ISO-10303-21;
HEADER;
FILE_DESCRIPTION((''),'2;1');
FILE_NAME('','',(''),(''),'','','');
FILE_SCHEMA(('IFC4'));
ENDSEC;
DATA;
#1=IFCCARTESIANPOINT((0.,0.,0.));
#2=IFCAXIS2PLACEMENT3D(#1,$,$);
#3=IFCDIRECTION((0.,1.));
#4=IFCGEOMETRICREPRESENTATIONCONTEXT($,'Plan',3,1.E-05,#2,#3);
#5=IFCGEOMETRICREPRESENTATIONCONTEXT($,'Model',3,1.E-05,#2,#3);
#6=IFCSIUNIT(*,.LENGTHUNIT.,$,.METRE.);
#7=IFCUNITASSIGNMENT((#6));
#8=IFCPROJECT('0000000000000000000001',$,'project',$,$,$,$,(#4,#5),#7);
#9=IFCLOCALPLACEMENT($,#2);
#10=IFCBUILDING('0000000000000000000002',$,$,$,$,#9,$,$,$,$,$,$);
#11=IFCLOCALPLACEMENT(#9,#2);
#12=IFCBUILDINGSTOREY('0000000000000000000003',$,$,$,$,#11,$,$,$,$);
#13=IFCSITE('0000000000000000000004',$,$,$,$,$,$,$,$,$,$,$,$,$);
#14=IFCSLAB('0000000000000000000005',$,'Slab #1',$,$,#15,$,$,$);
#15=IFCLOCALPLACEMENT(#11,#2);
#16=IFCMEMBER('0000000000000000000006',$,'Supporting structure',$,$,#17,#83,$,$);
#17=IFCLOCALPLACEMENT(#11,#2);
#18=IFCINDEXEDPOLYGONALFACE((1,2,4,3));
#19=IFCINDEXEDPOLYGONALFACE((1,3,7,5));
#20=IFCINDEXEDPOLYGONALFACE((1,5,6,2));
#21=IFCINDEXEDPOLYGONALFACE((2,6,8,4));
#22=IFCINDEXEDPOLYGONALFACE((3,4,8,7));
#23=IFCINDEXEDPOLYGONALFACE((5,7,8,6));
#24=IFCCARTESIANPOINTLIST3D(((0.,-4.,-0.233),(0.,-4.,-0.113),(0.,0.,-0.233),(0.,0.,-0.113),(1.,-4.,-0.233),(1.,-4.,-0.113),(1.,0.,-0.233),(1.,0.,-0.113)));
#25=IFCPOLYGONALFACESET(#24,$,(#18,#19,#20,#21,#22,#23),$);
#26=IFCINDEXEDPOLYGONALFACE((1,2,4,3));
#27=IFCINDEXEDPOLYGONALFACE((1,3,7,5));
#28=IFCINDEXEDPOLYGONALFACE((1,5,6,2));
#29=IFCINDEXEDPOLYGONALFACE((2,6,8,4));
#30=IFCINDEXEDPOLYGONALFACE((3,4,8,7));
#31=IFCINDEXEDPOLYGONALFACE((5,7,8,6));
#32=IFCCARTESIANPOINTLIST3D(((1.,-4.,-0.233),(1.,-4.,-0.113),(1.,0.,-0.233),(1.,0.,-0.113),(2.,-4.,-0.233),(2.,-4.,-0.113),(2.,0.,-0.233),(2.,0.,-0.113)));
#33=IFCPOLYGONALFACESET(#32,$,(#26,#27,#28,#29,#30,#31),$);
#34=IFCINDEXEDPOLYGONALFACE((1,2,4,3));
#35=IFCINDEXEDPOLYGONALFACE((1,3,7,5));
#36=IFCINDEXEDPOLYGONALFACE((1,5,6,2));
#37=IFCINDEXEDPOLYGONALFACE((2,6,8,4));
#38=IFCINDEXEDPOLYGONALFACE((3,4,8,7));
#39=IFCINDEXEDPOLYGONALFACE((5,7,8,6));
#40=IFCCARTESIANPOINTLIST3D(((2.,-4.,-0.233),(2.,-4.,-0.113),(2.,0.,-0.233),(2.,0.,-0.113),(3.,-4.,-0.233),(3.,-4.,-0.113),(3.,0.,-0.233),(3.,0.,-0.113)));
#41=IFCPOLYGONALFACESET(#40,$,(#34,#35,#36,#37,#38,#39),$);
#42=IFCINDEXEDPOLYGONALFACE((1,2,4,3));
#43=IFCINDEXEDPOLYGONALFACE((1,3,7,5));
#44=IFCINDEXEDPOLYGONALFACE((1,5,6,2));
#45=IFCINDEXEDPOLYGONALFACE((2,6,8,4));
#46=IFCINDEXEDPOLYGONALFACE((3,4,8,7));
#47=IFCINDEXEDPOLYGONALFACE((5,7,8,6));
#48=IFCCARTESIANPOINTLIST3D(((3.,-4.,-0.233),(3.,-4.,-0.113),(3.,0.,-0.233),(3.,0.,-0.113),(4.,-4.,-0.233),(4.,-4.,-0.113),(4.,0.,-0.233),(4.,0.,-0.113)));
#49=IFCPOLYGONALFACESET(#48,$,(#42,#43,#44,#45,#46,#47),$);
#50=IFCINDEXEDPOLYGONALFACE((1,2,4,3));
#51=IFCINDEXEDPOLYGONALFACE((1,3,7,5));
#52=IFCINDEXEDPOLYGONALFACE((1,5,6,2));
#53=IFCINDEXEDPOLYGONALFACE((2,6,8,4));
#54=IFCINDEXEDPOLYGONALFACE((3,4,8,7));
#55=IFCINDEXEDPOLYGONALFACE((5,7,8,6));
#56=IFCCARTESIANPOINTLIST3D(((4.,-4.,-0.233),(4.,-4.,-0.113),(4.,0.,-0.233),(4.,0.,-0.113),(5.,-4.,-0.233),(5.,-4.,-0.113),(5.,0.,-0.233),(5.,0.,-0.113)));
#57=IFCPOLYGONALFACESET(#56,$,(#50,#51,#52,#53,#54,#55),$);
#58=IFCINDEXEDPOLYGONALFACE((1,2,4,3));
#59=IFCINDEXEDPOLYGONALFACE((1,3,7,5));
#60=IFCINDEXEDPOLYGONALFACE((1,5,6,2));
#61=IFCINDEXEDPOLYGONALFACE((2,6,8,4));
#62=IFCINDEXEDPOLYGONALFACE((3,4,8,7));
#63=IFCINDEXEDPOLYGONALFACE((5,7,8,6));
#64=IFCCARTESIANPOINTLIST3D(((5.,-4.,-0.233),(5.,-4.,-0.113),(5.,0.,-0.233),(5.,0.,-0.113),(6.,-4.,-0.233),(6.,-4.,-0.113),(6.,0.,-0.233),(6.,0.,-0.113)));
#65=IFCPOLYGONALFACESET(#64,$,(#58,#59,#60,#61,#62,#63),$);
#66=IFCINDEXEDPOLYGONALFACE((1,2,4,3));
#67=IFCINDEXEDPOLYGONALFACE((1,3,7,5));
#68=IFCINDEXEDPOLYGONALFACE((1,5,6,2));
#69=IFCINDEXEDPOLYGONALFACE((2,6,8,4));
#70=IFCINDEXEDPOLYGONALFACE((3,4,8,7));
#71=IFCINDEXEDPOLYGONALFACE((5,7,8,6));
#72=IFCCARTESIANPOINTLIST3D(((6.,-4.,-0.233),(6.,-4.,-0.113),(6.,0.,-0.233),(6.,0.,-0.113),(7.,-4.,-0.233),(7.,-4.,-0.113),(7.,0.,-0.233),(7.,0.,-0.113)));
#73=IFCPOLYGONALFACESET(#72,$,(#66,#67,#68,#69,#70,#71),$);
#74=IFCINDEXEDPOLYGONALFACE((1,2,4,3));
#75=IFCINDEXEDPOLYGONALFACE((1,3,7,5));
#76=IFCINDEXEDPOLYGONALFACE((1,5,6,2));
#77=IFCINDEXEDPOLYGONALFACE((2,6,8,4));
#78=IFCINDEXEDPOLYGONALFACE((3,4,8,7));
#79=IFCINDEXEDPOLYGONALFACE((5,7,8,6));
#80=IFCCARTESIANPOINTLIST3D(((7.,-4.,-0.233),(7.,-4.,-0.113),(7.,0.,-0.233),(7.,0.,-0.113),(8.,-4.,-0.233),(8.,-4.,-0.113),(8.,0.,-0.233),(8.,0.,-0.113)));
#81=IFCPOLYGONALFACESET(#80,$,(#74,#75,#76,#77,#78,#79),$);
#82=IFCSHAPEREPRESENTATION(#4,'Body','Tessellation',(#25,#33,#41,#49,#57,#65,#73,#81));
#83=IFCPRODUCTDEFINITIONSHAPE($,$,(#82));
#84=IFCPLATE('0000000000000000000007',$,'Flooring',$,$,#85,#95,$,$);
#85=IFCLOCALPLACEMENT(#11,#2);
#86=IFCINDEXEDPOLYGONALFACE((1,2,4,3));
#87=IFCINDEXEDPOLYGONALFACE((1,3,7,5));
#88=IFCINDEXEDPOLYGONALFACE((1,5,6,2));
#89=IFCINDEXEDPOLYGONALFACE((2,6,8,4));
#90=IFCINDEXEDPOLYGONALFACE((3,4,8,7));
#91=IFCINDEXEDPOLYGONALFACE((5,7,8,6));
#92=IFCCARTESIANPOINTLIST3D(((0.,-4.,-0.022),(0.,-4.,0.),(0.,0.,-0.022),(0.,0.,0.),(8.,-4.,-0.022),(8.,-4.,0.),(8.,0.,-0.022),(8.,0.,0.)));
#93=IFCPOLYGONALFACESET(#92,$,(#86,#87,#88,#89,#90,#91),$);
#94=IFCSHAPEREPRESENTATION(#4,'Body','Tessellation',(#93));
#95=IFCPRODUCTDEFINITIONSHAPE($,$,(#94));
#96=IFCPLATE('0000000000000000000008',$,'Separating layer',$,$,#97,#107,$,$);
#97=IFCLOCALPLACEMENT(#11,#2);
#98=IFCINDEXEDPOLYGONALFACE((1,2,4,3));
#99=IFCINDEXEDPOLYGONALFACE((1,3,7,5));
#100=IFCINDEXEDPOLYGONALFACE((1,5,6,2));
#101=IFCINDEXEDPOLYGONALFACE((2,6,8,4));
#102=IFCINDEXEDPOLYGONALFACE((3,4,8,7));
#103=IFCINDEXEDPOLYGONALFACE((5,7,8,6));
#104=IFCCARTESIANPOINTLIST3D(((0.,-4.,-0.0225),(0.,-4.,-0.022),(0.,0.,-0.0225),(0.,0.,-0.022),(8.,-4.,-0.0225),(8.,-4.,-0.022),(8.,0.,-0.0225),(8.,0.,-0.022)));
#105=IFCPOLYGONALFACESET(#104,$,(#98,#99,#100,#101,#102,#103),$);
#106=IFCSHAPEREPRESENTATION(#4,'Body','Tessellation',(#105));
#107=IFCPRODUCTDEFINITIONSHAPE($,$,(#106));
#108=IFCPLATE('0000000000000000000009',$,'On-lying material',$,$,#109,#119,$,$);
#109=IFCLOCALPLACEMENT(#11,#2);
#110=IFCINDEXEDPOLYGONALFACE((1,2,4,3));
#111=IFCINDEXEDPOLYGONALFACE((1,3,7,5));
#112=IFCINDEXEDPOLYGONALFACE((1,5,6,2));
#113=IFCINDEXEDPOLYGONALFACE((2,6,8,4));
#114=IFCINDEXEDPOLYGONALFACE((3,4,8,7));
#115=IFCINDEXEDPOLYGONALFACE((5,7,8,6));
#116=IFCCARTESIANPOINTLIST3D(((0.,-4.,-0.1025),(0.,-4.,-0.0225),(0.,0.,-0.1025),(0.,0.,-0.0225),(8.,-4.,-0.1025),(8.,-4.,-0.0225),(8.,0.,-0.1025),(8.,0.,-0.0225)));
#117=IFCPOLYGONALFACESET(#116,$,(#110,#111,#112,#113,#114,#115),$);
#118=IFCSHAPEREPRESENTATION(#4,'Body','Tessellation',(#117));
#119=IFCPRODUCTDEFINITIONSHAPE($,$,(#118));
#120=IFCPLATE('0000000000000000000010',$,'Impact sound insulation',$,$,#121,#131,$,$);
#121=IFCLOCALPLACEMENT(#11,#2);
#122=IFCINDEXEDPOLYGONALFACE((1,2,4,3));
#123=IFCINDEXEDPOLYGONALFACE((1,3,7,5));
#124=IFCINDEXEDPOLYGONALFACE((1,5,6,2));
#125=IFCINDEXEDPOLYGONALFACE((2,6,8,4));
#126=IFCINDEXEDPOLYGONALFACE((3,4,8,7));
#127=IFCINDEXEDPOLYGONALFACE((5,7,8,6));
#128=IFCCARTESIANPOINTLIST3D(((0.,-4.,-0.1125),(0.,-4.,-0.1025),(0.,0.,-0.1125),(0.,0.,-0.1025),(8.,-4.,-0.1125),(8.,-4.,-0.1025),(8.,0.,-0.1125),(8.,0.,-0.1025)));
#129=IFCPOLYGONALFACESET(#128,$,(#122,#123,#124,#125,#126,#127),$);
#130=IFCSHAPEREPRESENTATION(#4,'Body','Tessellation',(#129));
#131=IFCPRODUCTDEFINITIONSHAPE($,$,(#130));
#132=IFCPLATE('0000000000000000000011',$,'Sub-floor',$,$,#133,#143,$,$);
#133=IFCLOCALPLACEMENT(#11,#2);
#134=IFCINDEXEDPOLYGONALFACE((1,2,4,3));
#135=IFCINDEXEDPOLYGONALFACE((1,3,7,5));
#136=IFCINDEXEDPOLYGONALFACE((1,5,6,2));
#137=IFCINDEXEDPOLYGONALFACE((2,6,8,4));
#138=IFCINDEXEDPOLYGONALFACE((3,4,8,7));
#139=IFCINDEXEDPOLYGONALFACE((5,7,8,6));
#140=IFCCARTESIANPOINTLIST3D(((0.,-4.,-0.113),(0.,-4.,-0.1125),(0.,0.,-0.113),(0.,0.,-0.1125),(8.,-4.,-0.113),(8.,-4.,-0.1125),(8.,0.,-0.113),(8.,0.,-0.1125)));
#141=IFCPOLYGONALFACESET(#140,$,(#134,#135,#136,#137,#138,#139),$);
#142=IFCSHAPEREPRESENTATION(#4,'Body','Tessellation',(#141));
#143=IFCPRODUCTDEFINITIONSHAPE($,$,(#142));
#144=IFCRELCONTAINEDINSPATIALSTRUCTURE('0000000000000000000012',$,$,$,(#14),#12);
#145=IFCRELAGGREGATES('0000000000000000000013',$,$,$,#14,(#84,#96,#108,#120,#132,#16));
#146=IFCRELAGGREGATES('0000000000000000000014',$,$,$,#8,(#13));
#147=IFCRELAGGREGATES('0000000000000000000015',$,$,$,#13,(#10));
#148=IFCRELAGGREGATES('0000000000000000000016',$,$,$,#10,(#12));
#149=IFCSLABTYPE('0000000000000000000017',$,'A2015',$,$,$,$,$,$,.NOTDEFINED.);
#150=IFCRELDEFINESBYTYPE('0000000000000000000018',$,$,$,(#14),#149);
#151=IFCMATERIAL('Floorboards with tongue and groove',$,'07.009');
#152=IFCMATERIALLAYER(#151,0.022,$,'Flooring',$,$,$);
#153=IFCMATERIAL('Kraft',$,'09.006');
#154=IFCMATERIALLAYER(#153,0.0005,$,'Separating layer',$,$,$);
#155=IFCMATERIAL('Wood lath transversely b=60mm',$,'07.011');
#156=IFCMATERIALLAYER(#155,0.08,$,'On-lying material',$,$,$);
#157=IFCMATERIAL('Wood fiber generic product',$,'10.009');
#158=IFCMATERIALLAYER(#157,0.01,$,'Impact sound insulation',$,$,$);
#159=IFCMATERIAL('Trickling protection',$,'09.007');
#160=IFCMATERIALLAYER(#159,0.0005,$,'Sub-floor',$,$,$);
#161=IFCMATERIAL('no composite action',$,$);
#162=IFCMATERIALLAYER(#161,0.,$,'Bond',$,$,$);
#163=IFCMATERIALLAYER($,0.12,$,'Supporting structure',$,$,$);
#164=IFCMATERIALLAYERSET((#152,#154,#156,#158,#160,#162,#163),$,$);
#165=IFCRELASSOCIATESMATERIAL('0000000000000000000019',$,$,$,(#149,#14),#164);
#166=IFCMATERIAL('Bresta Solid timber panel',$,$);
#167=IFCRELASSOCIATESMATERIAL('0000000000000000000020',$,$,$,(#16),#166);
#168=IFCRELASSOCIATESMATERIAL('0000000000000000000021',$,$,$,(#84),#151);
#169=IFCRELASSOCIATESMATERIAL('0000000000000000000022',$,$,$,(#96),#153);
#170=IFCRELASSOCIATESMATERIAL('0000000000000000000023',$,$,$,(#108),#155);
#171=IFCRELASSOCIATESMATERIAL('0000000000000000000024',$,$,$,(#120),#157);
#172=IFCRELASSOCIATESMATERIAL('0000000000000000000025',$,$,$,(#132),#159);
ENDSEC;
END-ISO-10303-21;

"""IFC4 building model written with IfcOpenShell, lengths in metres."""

from ifc_helpers import new_model, si_unit, direction, frame, frame_2d, origin, origin_with_axes, place, context, project, spatial, rectangle, extrude, material, layer, layer_set, type_object, element, aggregate, save


model = new_model("IFC4")

# Units and contexts
plan_context = context("Plan", 3, precision=1e-05, world=origin(), true_north=direction((0.0, 1.0)))
model_context = context("Model", 3, precision=1e-05, world=origin(), true_north=direction((0.0, 1.0)))
ifc_project = project(units=[si_unit("LENGTHUNIT", "METRE")], contexts=[plan_context, model_context])

# Site, building, storey
site = spatial("IfcSite", under=ifc_project)
building_placement = place(None, origin())
building = spatial("IfcBuilding", under=site, at=building_placement)
storey_placement = place(building_placement, origin())
storey = spatial("IfcBuildingStorey", under=building, at=storey_placement)

# Slab, member, plates
ifc_material_1 = material(Name="Floorboards with tongue and groove", Category="07.009")
ifc_layer_1 = layer(ifc_material_1, 0.022, Name="Flooring")
ifc_material_2 = material(Name="Kraft", Category="09.006")
ifc_layer_2 = layer(ifc_material_2, 0.0005, Name="Separating layer")
ifc_material_3 = material(Name="Wood lath transversely b=60mm", Category="07.011")
ifc_layer_3 = layer(ifc_material_3, 0.08, Name="On-lying material")
ifc_material_4 = material(Name="Wood fiber generic product", Category="10.009")
ifc_layer_4 = layer(ifc_material_4, 0.01, Name="Impact sound insulation")
ifc_material_5 = material(Name="Trickling protection", Category="09.007")
ifc_layer_5 = layer(ifc_material_5, 0.0005, Name="Sub-floor")
ifc_material_6 = material(Name="no composite action")
ifc_layer_6 = layer(ifc_material_6, 0.0, Name="Bond")
ifc_layer_7 = layer(None, 0.12, Name="Supporting structure")
ifc_layer_set = layer_set([ifc_layer_1, ifc_layer_2, ifc_layer_3, ifc_layer_4, ifc_layer_5, ifc_layer_6, ifc_layer_7])
slab_type = type_object("IfcSlabType", Name="A2015", PredefinedType="NOTDEFINED", material=ifc_layer_set)
slab_placement = place(None, frame((0.0, 0.0, 0.0), z_axis=(0.0, 0.0, -1.0), x_axis=(1.0, 0.0, 0.0)))
slab = element("IfcSlab", 1, at=slab_placement, inside=storey, type_object=slab_type, material=ifc_layer_set, Name="Slab #1")
ifc_material_7 = material(Name="Bresta Solid timber panel")
member_placement = place(slab_placement, origin())
member = element("IfcMember", 2, at=member_placement, material=ifc_material_7, Name="Supporting structure", context=plan_context, shape_type="SweptSolid", body=[
    extrude(rectangle(XDim=1.0, YDim=0.12, at=frame_2d((0.5, 0.06), x_axis=(1.0, 0.0))), frame((0.0, 4.0, 0.113), z_axis=(0.0, -1.0, 0.0), x_axis=(1.0, 0.0, 0.0)), (0.0, 0.0, 1.0), 4.0),
    extrude(rectangle(XDim=1.0, YDim=0.12, at=frame_2d((0.5, 0.06), x_axis=(1.0, 0.0))), frame((1.0, 4.0, 0.113), z_axis=(0.0, -1.0, 0.0), x_axis=(1.0, 0.0, 0.0)), (0.0, 0.0, 1.0), 4.0),
    extrude(rectangle(XDim=1.0, YDim=0.12, at=frame_2d((0.5, 0.06), x_axis=(1.0, 0.0))), frame((2.0, 4.0, 0.113), z_axis=(0.0, -1.0, 0.0), x_axis=(1.0, 0.0, 0.0)), (0.0, 0.0, 1.0), 4.0),
    extrude(rectangle(XDim=1.0, YDim=0.12, at=frame_2d((0.5, 0.06), x_axis=(1.0, 0.0))), frame((3.0, 4.0, 0.113), z_axis=(0.0, -1.0, 0.0), x_axis=(1.0, 0.0, 0.0)), (0.0, 0.0, 1.0), 4.0),
    extrude(rectangle(XDim=1.0, YDim=0.12, at=frame_2d((0.5, 0.06), x_axis=(1.0, 0.0))), frame((4.0, 4.0, 0.113), z_axis=(0.0, -1.0, 0.0), x_axis=(1.0, 0.0, 0.0)), (0.0, 0.0, 1.0), 4.0),
    extrude(rectangle(XDim=1.0, YDim=0.12, at=frame_2d((0.5, 0.06), x_axis=(1.0, 0.0))), frame((5.0, 4.0, 0.113), z_axis=(0.0, -1.0, 0.0), x_axis=(1.0, 0.0, 0.0)), (0.0, 0.0, 1.0), 4.0),
    extrude(rectangle(XDim=1.0, YDim=0.12, at=frame_2d((0.5, 0.06), x_axis=(1.0, 0.0))), frame((6.0, 4.0, 0.113), z_axis=(0.0, -1.0, 0.0), x_axis=(1.0, 0.0, 0.0)), (0.0, 0.0, 1.0), 4.0),
    extrude(rectangle(XDim=1.0, YDim=0.12, at=frame_2d((0.5, 0.06), x_axis=(1.0, 0.0))), frame((7.0, 4.0, 0.113), z_axis=(0.0, -1.0, 0.0), x_axis=(1.0, 0.0, 0.0)), (0.0, 0.0, 1.0), 4.0),
])
plate_1_placement = place(slab_placement, origin())
plate_1 = element("IfcPlate", 3, at=plate_1_placement, material=ifc_material_1, Name="Flooring", context=plan_context, shape_type="SweptSolid", body=[
    extrude(rectangle(XDim=8.0, YDim=4.0, at=frame_2d((4.0, 2.0), x_axis=(1.0, 0.0))), origin_with_axes(), (0.0, 0.0, 1.0), 0.022),
])
plate_2_placement = place(slab_placement, origin())
plate_2 = element("IfcPlate", 4, at=plate_2_placement, material=ifc_material_2, Name="Separating layer", context=plan_context, shape_type="SweptSolid", body=[
    extrude(rectangle(XDim=8.0, YDim=4.0, at=frame_2d((4.0, 2.0), x_axis=(1.0, 0.0))), frame((0.0, 0.0, 0.022), z_axis=(0.0, 0.0, 1.0), x_axis=(1.0, 0.0, 0.0)), (0.0, 0.0, 1.0), 0.0005),
])
plate_3_placement = place(slab_placement, origin())
plate_3 = element("IfcPlate", 5, at=plate_3_placement, material=ifc_material_3, Name="On-lying material", context=plan_context, shape_type="SweptSolid", body=[
    extrude(rectangle(XDim=8.0, YDim=4.0, at=frame_2d((4.0, 2.0), x_axis=(1.0, 0.0))), frame((0.0, 0.0, 0.0225), z_axis=(0.0, 0.0, 1.0), x_axis=(1.0, 0.0, 0.0)), (0.0, 0.0, 1.0), 0.08),
])
plate_4_placement = place(slab_placement, origin())
plate_4 = element("IfcPlate", 6, at=plate_4_placement, material=ifc_material_4, Name="Impact sound insulation", context=plan_context, shape_type="SweptSolid", body=[
    extrude(rectangle(XDim=8.0, YDim=4.0, at=frame_2d((4.0, 2.0), x_axis=(1.0, 0.0))), frame((0.0, 0.0, 0.1025), z_axis=(0.0, 0.0, 1.0), x_axis=(1.0, 0.0, 0.0)), (0.0, 0.0, 1.0), 0.01),
])
plate_5_placement = place(slab_placement, origin())
plate_5 = element("IfcPlate", 7, at=plate_5_placement, material=ifc_material_5, Name="Sub-floor", context=plan_context, shape_type="SweptSolid", body=[
    extrude(rectangle(XDim=8.0, YDim=4.0, at=frame_2d((4.0, 2.0), x_axis=(1.0, 0.0))), frame((0.0, 0.0, 0.1125), z_axis=(0.0, 0.0, 1.0), x_axis=(1.0, 0.0, 0.0)), (0.0, 0.0, 1.0), 0.0005),
])
aggregate(slab, [plate_1, plate_2, plate_3, plate_4, plate_5, member])

save(model, "model.ifc")
